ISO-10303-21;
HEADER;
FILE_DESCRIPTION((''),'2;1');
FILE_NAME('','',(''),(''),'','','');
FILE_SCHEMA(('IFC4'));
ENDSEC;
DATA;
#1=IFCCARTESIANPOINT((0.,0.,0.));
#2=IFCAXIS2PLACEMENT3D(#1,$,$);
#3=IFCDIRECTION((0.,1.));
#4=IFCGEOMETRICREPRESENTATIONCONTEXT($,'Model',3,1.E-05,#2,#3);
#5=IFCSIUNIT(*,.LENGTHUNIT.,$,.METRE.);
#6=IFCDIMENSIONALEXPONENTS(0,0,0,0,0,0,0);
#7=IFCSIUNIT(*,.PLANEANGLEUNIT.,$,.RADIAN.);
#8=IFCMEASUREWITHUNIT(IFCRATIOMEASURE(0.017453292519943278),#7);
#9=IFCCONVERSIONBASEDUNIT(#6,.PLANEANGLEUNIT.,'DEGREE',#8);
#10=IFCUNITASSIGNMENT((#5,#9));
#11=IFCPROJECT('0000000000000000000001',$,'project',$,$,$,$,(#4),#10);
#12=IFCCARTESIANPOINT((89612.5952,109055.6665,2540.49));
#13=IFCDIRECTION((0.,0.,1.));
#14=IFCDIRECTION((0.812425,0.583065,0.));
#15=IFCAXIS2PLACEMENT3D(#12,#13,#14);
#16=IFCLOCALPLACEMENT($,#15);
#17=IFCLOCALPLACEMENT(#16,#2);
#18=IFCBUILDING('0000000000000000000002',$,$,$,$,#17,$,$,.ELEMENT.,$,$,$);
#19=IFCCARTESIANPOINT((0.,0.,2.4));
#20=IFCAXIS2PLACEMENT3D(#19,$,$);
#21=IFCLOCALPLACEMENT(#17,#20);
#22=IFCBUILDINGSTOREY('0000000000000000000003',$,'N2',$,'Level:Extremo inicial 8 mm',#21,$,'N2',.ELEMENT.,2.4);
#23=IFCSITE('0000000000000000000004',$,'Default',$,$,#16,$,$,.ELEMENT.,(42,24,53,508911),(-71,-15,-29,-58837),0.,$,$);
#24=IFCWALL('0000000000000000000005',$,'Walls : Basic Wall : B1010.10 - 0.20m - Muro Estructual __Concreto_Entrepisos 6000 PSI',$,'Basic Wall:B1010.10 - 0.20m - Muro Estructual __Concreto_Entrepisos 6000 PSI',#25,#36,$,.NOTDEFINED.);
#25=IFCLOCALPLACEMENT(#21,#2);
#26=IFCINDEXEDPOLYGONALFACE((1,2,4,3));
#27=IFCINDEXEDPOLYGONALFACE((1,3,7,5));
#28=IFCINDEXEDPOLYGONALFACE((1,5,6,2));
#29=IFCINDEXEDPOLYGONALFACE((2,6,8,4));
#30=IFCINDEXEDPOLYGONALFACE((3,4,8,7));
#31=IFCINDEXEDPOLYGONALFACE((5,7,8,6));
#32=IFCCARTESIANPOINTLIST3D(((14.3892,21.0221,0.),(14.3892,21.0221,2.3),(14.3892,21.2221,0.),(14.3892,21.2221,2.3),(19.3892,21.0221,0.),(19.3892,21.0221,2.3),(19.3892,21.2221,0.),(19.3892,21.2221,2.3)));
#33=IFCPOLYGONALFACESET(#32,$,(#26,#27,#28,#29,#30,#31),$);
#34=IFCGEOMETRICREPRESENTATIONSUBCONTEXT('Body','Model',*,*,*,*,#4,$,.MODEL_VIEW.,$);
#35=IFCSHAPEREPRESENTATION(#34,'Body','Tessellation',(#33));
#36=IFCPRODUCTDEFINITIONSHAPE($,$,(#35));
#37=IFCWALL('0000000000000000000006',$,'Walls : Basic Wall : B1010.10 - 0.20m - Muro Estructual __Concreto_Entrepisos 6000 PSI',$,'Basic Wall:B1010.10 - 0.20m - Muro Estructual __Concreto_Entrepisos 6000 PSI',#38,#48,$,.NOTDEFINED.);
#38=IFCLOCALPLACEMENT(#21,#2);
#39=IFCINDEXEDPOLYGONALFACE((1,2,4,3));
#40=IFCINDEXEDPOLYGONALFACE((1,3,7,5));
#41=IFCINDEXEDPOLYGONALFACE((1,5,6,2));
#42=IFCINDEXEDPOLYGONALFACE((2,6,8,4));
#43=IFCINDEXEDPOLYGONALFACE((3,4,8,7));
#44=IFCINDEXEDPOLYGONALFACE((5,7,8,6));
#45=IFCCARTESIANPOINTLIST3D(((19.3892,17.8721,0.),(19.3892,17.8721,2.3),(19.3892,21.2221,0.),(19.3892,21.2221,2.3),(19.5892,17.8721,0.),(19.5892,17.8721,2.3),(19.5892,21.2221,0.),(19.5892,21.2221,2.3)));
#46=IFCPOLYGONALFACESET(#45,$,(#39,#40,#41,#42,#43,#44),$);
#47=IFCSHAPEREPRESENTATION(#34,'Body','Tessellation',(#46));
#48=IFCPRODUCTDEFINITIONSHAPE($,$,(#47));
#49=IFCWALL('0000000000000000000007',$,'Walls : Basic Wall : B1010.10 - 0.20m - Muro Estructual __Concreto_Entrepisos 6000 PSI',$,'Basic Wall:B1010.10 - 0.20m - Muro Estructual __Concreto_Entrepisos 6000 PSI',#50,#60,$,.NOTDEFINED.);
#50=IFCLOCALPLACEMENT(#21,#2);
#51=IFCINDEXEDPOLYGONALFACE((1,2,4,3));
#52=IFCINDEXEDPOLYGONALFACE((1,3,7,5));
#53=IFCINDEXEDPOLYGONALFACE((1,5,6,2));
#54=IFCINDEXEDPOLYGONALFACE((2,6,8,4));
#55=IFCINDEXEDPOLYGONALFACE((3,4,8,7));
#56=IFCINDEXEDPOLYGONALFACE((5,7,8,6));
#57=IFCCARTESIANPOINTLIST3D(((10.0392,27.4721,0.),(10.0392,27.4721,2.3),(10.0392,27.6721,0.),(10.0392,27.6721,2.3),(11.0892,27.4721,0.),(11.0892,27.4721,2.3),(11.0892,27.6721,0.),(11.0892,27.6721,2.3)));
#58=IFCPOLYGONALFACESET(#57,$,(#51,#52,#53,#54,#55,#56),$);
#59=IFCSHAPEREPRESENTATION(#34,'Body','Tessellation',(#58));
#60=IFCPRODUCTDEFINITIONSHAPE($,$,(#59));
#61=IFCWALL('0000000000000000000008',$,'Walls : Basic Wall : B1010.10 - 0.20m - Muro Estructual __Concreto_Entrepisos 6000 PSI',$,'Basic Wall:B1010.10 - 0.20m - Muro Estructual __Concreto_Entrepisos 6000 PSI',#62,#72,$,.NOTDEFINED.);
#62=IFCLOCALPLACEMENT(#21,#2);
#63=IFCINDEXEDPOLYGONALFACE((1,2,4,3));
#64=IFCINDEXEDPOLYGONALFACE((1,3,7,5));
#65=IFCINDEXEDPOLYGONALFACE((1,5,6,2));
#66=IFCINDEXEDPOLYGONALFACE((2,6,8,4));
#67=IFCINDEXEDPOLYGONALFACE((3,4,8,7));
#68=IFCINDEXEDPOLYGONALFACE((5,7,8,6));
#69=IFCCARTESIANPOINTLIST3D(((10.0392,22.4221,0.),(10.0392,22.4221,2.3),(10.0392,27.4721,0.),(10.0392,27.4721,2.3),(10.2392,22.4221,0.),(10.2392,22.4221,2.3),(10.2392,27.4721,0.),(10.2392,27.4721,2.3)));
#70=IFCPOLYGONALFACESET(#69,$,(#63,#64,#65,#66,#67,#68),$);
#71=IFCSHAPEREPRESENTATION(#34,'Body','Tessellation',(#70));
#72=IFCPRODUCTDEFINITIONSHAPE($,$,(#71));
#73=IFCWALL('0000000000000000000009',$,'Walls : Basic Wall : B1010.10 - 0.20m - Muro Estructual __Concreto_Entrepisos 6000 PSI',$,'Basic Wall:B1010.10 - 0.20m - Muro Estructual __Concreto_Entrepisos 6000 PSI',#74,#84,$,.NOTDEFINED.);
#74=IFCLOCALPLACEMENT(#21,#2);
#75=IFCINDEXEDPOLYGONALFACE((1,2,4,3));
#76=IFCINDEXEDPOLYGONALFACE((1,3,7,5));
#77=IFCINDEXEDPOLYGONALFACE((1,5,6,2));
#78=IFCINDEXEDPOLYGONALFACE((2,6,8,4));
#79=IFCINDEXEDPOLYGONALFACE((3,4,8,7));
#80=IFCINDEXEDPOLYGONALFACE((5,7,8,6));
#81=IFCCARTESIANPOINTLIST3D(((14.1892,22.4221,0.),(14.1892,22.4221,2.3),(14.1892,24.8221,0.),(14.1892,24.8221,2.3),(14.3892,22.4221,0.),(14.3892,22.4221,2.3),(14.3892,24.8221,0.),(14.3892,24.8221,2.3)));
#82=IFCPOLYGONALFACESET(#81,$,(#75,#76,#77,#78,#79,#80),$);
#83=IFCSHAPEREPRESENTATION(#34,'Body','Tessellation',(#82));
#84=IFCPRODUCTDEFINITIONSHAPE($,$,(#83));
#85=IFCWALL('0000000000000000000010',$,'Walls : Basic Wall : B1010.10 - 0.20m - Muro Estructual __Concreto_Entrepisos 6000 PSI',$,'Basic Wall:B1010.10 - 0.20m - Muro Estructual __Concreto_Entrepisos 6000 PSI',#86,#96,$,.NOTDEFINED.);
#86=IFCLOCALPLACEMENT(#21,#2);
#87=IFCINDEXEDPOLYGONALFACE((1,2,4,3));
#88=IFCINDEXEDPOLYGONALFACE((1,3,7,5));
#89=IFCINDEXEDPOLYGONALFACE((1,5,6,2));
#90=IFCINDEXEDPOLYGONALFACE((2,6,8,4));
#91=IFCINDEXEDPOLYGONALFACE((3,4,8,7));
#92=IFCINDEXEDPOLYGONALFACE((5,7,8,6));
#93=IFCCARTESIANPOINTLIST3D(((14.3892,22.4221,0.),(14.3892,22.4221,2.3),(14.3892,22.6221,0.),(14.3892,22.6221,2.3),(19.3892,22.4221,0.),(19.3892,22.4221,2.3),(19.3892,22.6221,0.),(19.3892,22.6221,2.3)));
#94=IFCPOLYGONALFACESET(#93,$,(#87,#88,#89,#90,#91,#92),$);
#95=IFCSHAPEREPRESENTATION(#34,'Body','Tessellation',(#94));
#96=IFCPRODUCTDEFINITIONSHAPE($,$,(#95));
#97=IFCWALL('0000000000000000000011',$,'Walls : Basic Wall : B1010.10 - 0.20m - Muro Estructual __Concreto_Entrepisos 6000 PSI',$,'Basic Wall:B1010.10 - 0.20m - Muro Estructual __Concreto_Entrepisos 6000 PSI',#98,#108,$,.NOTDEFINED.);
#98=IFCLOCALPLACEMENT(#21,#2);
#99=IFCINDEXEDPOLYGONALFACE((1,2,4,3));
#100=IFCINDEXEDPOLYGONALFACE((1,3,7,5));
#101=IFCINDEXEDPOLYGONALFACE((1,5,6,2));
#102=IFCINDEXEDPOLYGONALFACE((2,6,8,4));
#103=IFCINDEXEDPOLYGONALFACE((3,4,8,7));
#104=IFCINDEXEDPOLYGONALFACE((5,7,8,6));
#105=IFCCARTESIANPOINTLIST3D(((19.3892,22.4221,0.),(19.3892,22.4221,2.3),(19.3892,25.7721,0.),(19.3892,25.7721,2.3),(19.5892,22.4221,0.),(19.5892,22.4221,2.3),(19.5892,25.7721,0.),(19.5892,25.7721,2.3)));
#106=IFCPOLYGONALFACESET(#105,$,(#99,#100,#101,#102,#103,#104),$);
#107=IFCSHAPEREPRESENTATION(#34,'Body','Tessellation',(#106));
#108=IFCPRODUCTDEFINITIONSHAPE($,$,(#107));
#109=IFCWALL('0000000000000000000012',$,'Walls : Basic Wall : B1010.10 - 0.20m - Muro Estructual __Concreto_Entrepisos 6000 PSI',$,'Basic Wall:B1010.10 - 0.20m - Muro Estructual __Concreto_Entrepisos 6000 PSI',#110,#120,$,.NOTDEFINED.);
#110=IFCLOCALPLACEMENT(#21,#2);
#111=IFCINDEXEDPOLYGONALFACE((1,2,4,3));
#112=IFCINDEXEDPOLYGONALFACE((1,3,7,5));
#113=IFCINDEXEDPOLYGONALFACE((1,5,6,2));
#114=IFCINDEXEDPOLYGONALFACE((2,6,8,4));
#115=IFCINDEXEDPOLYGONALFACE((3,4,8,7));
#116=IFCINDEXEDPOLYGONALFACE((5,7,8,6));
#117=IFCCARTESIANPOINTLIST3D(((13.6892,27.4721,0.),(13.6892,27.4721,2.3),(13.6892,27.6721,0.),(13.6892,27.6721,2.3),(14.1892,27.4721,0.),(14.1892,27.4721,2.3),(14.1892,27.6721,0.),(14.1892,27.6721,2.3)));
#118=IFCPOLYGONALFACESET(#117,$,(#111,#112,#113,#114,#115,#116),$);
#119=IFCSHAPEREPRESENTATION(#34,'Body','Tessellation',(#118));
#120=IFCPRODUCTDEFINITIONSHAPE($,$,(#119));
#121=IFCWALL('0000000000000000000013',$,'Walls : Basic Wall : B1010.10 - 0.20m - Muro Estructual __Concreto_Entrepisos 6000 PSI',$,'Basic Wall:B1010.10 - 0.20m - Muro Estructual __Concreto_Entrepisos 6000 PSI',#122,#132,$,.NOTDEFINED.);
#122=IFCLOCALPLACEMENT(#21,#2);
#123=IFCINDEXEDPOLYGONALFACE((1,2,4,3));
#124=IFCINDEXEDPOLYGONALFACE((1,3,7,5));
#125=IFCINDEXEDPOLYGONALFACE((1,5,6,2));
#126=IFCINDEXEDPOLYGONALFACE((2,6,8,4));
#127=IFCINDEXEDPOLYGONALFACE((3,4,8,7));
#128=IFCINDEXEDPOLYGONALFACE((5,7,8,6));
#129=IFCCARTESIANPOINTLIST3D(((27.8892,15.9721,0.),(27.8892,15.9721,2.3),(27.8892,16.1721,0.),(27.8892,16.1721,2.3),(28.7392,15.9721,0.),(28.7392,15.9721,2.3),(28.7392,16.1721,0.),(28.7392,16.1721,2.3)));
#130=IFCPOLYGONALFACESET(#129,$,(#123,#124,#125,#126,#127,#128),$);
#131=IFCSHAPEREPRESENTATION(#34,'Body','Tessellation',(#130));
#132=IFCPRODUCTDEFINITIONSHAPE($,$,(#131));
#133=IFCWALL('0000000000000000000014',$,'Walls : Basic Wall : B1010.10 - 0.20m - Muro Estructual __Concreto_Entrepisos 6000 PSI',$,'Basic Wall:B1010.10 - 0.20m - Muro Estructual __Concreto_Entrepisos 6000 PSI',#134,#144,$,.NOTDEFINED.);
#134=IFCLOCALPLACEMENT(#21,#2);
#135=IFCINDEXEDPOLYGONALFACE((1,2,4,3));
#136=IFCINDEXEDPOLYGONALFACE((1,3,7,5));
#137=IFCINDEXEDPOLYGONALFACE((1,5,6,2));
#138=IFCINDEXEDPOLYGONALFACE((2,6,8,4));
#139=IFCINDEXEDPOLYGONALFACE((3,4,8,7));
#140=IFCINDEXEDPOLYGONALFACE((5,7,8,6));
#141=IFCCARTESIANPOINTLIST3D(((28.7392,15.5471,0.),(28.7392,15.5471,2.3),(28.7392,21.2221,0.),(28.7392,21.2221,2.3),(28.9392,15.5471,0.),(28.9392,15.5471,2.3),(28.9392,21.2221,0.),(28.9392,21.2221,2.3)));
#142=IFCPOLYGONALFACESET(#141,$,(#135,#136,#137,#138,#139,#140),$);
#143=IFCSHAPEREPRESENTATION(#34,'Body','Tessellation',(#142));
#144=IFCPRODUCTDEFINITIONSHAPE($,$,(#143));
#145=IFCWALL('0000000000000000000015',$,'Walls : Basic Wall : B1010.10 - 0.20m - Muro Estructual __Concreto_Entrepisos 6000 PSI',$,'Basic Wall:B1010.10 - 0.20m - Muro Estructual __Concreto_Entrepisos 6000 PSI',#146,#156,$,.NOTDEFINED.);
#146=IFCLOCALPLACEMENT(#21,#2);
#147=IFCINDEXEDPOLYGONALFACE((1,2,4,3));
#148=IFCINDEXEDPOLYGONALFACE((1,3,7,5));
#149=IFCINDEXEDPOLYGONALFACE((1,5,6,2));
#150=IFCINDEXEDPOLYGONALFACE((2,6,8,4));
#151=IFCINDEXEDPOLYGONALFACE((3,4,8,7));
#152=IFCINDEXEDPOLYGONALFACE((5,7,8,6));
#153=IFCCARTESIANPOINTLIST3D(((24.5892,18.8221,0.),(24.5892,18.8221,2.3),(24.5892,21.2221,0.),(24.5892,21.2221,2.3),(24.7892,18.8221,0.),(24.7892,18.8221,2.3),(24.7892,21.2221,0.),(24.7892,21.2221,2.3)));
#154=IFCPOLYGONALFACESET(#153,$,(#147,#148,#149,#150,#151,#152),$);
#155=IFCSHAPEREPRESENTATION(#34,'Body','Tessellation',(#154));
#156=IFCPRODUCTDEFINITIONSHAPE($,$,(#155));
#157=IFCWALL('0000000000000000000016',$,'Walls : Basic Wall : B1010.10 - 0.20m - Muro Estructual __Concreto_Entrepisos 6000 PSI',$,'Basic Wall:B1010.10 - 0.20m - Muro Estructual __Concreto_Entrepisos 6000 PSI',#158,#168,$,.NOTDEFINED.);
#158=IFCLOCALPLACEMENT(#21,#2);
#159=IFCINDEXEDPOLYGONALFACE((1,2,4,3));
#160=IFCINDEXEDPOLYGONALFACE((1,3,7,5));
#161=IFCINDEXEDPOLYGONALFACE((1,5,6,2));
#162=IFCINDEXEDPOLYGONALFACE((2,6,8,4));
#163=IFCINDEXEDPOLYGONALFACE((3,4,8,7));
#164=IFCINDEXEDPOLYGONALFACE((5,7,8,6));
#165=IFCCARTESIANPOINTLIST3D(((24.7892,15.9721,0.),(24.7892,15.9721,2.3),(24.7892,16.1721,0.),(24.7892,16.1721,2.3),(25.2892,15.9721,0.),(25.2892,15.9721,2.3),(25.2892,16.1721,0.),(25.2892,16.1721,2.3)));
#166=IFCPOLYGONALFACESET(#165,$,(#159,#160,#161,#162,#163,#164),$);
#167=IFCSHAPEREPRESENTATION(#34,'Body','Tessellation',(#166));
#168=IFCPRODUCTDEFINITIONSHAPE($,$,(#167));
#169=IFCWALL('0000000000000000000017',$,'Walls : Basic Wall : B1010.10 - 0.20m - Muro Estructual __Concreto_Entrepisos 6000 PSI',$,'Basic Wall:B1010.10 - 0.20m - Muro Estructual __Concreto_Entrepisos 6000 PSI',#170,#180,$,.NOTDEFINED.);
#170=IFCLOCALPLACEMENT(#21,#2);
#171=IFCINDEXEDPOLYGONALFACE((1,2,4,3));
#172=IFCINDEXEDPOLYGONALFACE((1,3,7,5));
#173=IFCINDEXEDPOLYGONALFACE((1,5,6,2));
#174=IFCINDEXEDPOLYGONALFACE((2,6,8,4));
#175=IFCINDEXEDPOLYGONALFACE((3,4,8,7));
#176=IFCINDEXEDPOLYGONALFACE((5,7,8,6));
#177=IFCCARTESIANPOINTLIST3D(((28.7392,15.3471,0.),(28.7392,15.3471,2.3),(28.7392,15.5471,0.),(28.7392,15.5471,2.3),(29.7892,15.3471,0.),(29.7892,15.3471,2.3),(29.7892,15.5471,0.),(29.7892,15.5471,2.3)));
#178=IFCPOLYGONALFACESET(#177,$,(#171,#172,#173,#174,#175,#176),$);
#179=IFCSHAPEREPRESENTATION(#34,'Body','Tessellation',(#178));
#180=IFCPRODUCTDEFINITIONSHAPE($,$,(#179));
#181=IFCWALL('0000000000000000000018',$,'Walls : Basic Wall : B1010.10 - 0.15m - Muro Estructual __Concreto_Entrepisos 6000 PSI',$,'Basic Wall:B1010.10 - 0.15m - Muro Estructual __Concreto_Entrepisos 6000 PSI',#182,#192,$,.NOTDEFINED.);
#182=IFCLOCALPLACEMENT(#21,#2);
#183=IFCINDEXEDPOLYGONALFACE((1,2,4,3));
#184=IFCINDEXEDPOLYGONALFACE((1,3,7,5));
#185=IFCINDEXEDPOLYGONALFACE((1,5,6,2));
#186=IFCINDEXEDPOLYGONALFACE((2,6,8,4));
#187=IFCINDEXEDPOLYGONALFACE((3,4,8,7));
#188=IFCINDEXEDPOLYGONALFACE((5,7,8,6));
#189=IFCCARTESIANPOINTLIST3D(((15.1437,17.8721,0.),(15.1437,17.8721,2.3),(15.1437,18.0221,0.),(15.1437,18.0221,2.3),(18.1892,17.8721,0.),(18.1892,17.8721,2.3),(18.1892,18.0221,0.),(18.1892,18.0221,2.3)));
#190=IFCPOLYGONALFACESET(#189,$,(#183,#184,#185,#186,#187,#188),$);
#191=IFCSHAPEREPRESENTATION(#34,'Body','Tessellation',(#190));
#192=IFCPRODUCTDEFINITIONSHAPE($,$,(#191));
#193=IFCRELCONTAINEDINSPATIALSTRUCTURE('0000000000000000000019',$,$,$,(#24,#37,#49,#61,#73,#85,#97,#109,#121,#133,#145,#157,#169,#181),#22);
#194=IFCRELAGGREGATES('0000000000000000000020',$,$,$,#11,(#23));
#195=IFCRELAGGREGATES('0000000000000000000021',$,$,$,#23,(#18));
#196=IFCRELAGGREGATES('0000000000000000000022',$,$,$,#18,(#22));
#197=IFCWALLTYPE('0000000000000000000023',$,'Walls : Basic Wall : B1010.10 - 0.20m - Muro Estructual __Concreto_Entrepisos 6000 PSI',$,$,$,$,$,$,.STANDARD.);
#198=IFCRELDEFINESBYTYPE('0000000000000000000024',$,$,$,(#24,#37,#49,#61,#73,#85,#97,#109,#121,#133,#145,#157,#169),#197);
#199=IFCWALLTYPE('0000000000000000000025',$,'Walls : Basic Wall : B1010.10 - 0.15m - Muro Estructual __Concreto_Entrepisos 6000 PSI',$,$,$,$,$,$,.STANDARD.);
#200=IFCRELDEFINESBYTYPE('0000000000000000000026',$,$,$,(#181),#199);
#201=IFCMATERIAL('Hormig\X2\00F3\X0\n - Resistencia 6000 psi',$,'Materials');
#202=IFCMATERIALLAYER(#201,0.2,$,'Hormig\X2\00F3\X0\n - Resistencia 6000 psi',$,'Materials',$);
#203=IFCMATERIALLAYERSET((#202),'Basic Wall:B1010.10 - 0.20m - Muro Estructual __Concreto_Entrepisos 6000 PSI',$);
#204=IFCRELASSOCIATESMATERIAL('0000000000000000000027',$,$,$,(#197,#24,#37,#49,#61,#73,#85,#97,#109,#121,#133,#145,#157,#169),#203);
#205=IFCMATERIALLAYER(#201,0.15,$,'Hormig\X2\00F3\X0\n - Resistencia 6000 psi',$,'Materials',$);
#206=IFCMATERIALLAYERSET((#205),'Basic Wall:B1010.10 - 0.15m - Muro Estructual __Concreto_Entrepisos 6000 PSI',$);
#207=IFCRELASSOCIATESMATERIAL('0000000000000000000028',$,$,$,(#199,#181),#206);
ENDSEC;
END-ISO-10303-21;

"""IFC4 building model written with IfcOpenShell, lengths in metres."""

from ifc_helpers import new_model, entity, si_unit, converted_unit, direction, frame, frame_2d, origin, place, context, subcontext, project, spatial, rectangle, extrude, material, layer, layer_set, layer_usage, type_object, element, save


model = new_model("IFC4")

# Units and contexts
model_context = context("Model", 3, precision=1e-05, world=origin(), true_north=direction((0.0, 1.0)))
body_context = subcontext(model_context, "Body", "Model", "MODEL_VIEW")
ifc_project = project(units=[si_unit("LENGTHUNIT", "METRE"), converted_unit("PLANEANGLEUNIT", "DEGREE", entity("IfcRatioMeasure", 0.017453292519943278), si_unit("PLANEANGLEUNIT", "RADIAN"), dimensions=[0, 0, 0, 0, 0, 0, 0])], contexts=[model_context])

# Site, building, storey
site_placement = place(None, frame((89612.5952, 109055.6665, 2540.49), z_axis=(0.0, 0.0, 1.0), x_axis=(0.812425, 0.583065, 0.0)))
site = spatial("IfcSite", under=ifc_project, at=site_placement, Name="Default", CompositionType="ELEMENT", RefLatitude=(42, 24, 53, 508911), RefLongitude=(-71, -15, -29, -58837), RefElevation=0.0)
building_placement = place(site_placement, origin())
building = spatial("IfcBuilding", under=site, at=building_placement, CompositionType="ELEMENT")
storey_placement = place(building_placement, frame((0.0, 0.0, 2.4)))
storey = spatial("IfcBuildingStorey", under=building, at=storey_placement, Name="N2", ObjectType="Level:Extremo inicial 8 mm", LongName="N2", CompositionType="ELEMENT", Elevation=2.4)

# Walls
ifc_material = material(Name="Hormigón - Resistencia 6000 psi", Category="Materials")
ifc_layer_1 = layer(ifc_material, 0.2, Name="Hormigón - Resistencia 6000 psi", Category="Materials")
ifc_layer_set_1 = layer_set([ifc_layer_1], Name="Basic Wall:B1010.10 - 0.20m - Muro Estructual __Concreto_Entrepisos 6000 PSI")
ifc_layer_usage_1 = layer_usage(ifc_layer_set_1, "AXIS2", "NEGATIVE", 0.1)
wall_type_1 = type_object("IfcWallType", Name="Walls : Basic Wall : B1010.10 - 0.20m - Muro Estructual __Concreto_Entrepisos 6000 PSI", PredefinedType="STANDARD", material=ifc_layer_set_1)
wall_1_placement = place(storey_placement, frame((14.3892, 21.1221, 0.0)))
element("IfcWall", 1, at=wall_1_placement, inside=storey, type_object=wall_type_1, material=ifc_layer_usage_1, Name="Walls : Basic Wall : B1010.10 - 0.20m - Muro Estructual __Concreto_Entrepisos 6000 PSI", ObjectType="Basic Wall:B1010.10 - 0.20m - Muro Estructual __Concreto_Entrepisos 6000 PSI", PredefinedType="NOTDEFINED", context=body_context, shape_type="SweptSolid", body=[
    extrude(rectangle(XDim=5.0, YDim=0.2, at=frame_2d((2.5, 0.0), x_axis=(-1.0, 0.0))), origin(), (0.0, 0.0, 1.0), 2.3),
])
ifc_layer_usage_2 = layer_usage(ifc_layer_set_1, "AXIS2", "NEGATIVE", 0.1)
wall_2_placement = place(storey_placement, frame((19.4892, 21.2221, 0.0), z_axis=(0.0, 0.0, 1.0), x_axis=(0.0, -1.0, 0.0)))
element("IfcWall", 2, at=wall_2_placement, inside=storey, type_object=wall_type_1, material=ifc_layer_usage_2, Name="Walls : Basic Wall : B1010.10 - 0.20m - Muro Estructual __Concreto_Entrepisos 6000 PSI", ObjectType="Basic Wall:B1010.10 - 0.20m - Muro Estructual __Concreto_Entrepisos 6000 PSI", PredefinedType="NOTDEFINED", context=body_context, shape_type="SweptSolid", body=[
    extrude(rectangle(XDim=3.35, YDim=0.2, at=frame_2d((1.675, 0.0), x_axis=(-1.0, 0.0))), origin(), (0.0, 0.0, 1.0), 2.3),
])
ifc_layer_usage_3 = layer_usage(ifc_layer_set_1, "AXIS2", "POSITIVE", -0.1)
wall_3_placement = place(storey_placement, frame((11.0892, 27.5721, 0.0), z_axis=(0.0, 0.0, 1.0), x_axis=(-1.0, 0.0, 0.0)))
element("IfcWall", 3, at=wall_3_placement, inside=storey, type_object=wall_type_1, material=ifc_layer_usage_3, Name="Walls : Basic Wall : B1010.10 - 0.20m - Muro Estructual __Concreto_Entrepisos 6000 PSI", ObjectType="Basic Wall:B1010.10 - 0.20m - Muro Estructual __Concreto_Entrepisos 6000 PSI", PredefinedType="NOTDEFINED", context=body_context, shape_type="SweptSolid", body=[
    extrude(rectangle(XDim=1.05, YDim=0.2, at=frame_2d((0.525, 0.0), x_axis=(-1.0, 0.0))), origin(), (0.0, 0.0, 1.0), 2.3),
])
ifc_layer_usage_4 = layer_usage(ifc_layer_set_1, "AXIS2", "POSITIVE", -0.1)
wall_4_placement = place(storey_placement, frame((10.1392, 27.4721, 0.0), z_axis=(0.0, 0.0, 1.0), x_axis=(0.0, -1.0, 0.0)))
element("IfcWall", 4, at=wall_4_placement, inside=storey, type_object=wall_type_1, material=ifc_layer_usage_4, Name="Walls : Basic Wall : B1010.10 - 0.20m - Muro Estructual __Concreto_Entrepisos 6000 PSI", ObjectType="Basic Wall:B1010.10 - 0.20m - Muro Estructual __Concreto_Entrepisos 6000 PSI", PredefinedType="NOTDEFINED", context=body_context, shape_type="SweptSolid", body=[
    extrude(rectangle(XDim=5.05, YDim=0.2, at=frame_2d((2.525, 0.0), x_axis=(-1.0, 0.0))), origin(), (0.0, 0.0, 1.0), 2.3),
])
ifc_layer_usage_5 = layer_usage(ifc_layer_set_1, "AXIS2", "POSITIVE", -0.1)
wall_5_placement = place(storey_placement, frame((14.2892, 24.8221, 0.0), z_axis=(0.0, 0.0, 1.0), x_axis=(0.0, -1.0, 0.0)))
element("IfcWall", 5, at=wall_5_placement, inside=storey, type_object=wall_type_1, material=ifc_layer_usage_5, Name="Walls : Basic Wall : B1010.10 - 0.20m - Muro Estructual __Concreto_Entrepisos 6000 PSI", ObjectType="Basic Wall:B1010.10 - 0.20m - Muro Estructual __Concreto_Entrepisos 6000 PSI", PredefinedType="NOTDEFINED", context=body_context, shape_type="SweptSolid", body=[
    extrude(rectangle(XDim=2.4, YDim=0.2, at=frame_2d((1.2, 0.0), x_axis=(-1.0, 0.0))), origin(), (0.0, 0.0, 1.0), 2.3),
])
ifc_layer_usage_6 = layer_usage(ifc_layer_set_1, "AXIS2", "POSITIVE", -0.1)
wall_6_placement = place(storey_placement, frame((14.3892, 22.5221, 0.0)))
element("IfcWall", 6, at=wall_6_placement, inside=storey, type_object=wall_type_1, material=ifc_layer_usage_6, Name="Walls : Basic Wall : B1010.10 - 0.20m - Muro Estructual __Concreto_Entrepisos 6000 PSI", ObjectType="Basic Wall:B1010.10 - 0.20m - Muro Estructual __Concreto_Entrepisos 6000 PSI", PredefinedType="NOTDEFINED", context=body_context, shape_type="SweptSolid", body=[
    extrude(rectangle(XDim=5.0, YDim=0.2, at=frame_2d((2.5, 0.0), x_axis=(-1.0, 0.0))), origin(), (0.0, 0.0, 1.0), 2.3),
])
ifc_layer_usage_7 = layer_usage(ifc_layer_set_1, "AXIS2", "POSITIVE", -0.1)
wall_7_placement = place(storey_placement, frame((19.4892, 22.4221, 0.0), z_axis=(0.0, 0.0, 1.0), x_axis=(0.0, 1.0, 0.0)))
element("IfcWall", 7, at=wall_7_placement, inside=storey, type_object=wall_type_1, material=ifc_layer_usage_7, Name="Walls : Basic Wall : B1010.10 - 0.20m - Muro Estructual __Concreto_Entrepisos 6000 PSI", ObjectType="Basic Wall:B1010.10 - 0.20m - Muro Estructual __Concreto_Entrepisos 6000 PSI", PredefinedType="NOTDEFINED", context=body_context, shape_type="SweptSolid", body=[
    extrude(rectangle(XDim=3.35, YDim=0.2, at=frame_2d((1.675, 0.0), x_axis=(-1.0, 0.0))), origin(), (0.0, 0.0, 1.0), 2.3),
])
ifc_layer_usage_8 = layer_usage(ifc_layer_set_1, "AXIS2", "POSITIVE", -0.1)
wall_8_placement = place(storey_placement, frame((13.6892, 27.5721, 0.0)))
element("IfcWall", 8, at=wall_8_placement, inside=storey, type_object=wall_type_1, material=ifc_layer_usage_8, Name="Walls : Basic Wall : B1010.10 - 0.20m - Muro Estructual __Concreto_Entrepisos 6000 PSI", ObjectType="Basic Wall:B1010.10 - 0.20m - Muro Estructual __Concreto_Entrepisos 6000 PSI", PredefinedType="NOTDEFINED", context=body_context, shape_type="SweptSolid", body=[
    extrude(rectangle(XDim=0.5, YDim=0.2, at=frame_2d((0.25, 0.0), x_axis=(-1.0, 0.0))), origin(), (0.0, 0.0, 1.0), 2.3),
])
ifc_layer_usage_9 = layer_usage(ifc_layer_set_1, "AXIS2", "POSITIVE", -0.1)
wall_9_placement = place(storey_placement, frame((27.8892, 16.0721, 0.0)))
element("IfcWall", 9, at=wall_9_placement, inside=storey, type_object=wall_type_1, material=ifc_layer_usage_9, Name="Walls : Basic Wall : B1010.10 - 0.20m - Muro Estructual __Concreto_Entrepisos 6000 PSI", ObjectType="Basic Wall:B1010.10 - 0.20m - Muro Estructual __Concreto_Entrepisos 6000 PSI", PredefinedType="NOTDEFINED", context=body_context, shape_type="SweptSolid", body=[
    extrude(rectangle(XDim=0.85, YDim=0.2, at=frame_2d((0.425, 0.0), x_axis=(-1.0, 0.0))), origin(), (0.0, 0.0, 1.0), 2.3),
])
ifc_layer_usage_10 = layer_usage(ifc_layer_set_1, "AXIS2", "POSITIVE", -0.1)
wall_10_placement = place(storey_placement, frame((28.8392, 15.5471, 0.0), z_axis=(0.0, 0.0, 1.0), x_axis=(0.0, 1.0, 0.0)))
element("IfcWall", 10, at=wall_10_placement, inside=storey, type_object=wall_type_1, material=ifc_layer_usage_10, Name="Walls : Basic Wall : B1010.10 - 0.20m - Muro Estructual __Concreto_Entrepisos 6000 PSI", ObjectType="Basic Wall:B1010.10 - 0.20m - Muro Estructual __Concreto_Entrepisos 6000 PSI", PredefinedType="NOTDEFINED", context=body_context, shape_type="SweptSolid", body=[
    extrude(rectangle(XDim=5.675, YDim=0.2, at=frame_2d((2.8375, 0.0), x_axis=(-1.0, 0.0))), origin(), (0.0, 0.0, 1.0), 2.3),
])
ifc_layer_usage_11 = layer_usage(ifc_layer_set_1, "AXIS2", "POSITIVE", -0.1)
wall_11_placement = place(storey_placement, frame((24.6892, 18.8221, 0.0), z_axis=(0.0, 0.0, 1.0), x_axis=(0.0, 1.0, 0.0)))
element("IfcWall", 11, at=wall_11_placement, inside=storey, type_object=wall_type_1, material=ifc_layer_usage_11, Name="Walls : Basic Wall : B1010.10 - 0.20m - Muro Estructual __Concreto_Entrepisos 6000 PSI", ObjectType="Basic Wall:B1010.10 - 0.20m - Muro Estructual __Concreto_Entrepisos 6000 PSI", PredefinedType="NOTDEFINED", context=body_context, shape_type="SweptSolid", body=[
    extrude(rectangle(XDim=2.4, YDim=0.2, at=frame_2d((1.2, 0.0), x_axis=(-1.0, 0.0))), origin(), (0.0, 0.0, 1.0), 2.3),
])
ifc_layer_usage_12 = layer_usage(ifc_layer_set_1, "AXIS2", "POSITIVE", -0.1)
wall_12_placement = place(storey_placement, frame((25.2892, 16.0721, 0.0), z_axis=(0.0, 0.0, 1.0), x_axis=(-1.0, 0.0, 0.0)))
element("IfcWall", 12, at=wall_12_placement, inside=storey, type_object=wall_type_1, material=ifc_layer_usage_12, Name="Walls : Basic Wall : B1010.10 - 0.20m - Muro Estructual __Concreto_Entrepisos 6000 PSI", ObjectType="Basic Wall:B1010.10 - 0.20m - Muro Estructual __Concreto_Entrepisos 6000 PSI", PredefinedType="NOTDEFINED", context=body_context, shape_type="SweptSolid", body=[
    extrude(rectangle(XDim=0.5, YDim=0.2, at=frame_2d((0.25, 0.0), x_axis=(-1.0, 0.0))), origin(), (0.0, 0.0, 1.0), 2.3),
])
ifc_layer_usage_13 = layer_usage(ifc_layer_set_1, "AXIS2", "NEGATIVE", 0.1)
wall_13_placement = place(storey_placement, frame((29.7892, 15.4471, 0.0), z_axis=(0.0, 0.0, 1.0), x_axis=(-1.0, 0.0, 0.0)))
element("IfcWall", 13, at=wall_13_placement, inside=storey, type_object=wall_type_1, material=ifc_layer_usage_13, Name="Walls : Basic Wall : B1010.10 - 0.20m - Muro Estructual __Concreto_Entrepisos 6000 PSI", ObjectType="Basic Wall:B1010.10 - 0.20m - Muro Estructual __Concreto_Entrepisos 6000 PSI", PredefinedType="NOTDEFINED", context=body_context, shape_type="SweptSolid", body=[
    extrude(rectangle(XDim=1.05, YDim=0.2, at=frame_2d((0.525, 0.0), x_axis=(-1.0, 0.0))), origin(), (0.0, 0.0, 1.0), 2.3),
])
ifc_layer_2 = layer(ifc_material, 0.15, Name="Hormigón - Resistencia 6000 psi", Category="Materials")
ifc_layer_set_2 = layer_set([ifc_layer_2], Name="Basic Wall:B1010.10 - 0.15m - Muro Estructual __Concreto_Entrepisos 6000 PSI")
ifc_layer_usage_14 = layer_usage(ifc_layer_set_2, "AXIS2", "NEGATIVE", 0.075)
wall_type_2 = type_object("IfcWallType", Name="Walls : Basic Wall : B1010.10 - 0.15m - Muro Estructual __Concreto_Entrepisos 6000 PSI", PredefinedType="STANDARD", material=ifc_layer_set_2)
wall_14_placement = place(storey_placement, frame((18.1892, 17.9471, 0.0), z_axis=(0.0, 0.0, 1.0), x_axis=(-1.0, 0.0, 0.0)))
element("IfcWall", 14, at=wall_14_placement, inside=storey, type_object=wall_type_2, material=ifc_layer_usage_14, Name="Walls : Basic Wall : B1010.10 - 0.15m - Muro Estructual __Concreto_Entrepisos 6000 PSI", ObjectType="Basic Wall:B1010.10 - 0.15m - Muro Estructual __Concreto_Entrepisos 6000 PSI", PredefinedType="NOTDEFINED", context=body_context, shape_type="SweptSolid", body=[
    extrude(rectangle(XDim=3.0455, YDim=0.15, at=frame_2d((1.5228, 0.0), x_axis=(-1.0, 0.0))), origin(), (0.0, 0.0, 1.0), 2.3),
])

save(model, "model.ifc")
